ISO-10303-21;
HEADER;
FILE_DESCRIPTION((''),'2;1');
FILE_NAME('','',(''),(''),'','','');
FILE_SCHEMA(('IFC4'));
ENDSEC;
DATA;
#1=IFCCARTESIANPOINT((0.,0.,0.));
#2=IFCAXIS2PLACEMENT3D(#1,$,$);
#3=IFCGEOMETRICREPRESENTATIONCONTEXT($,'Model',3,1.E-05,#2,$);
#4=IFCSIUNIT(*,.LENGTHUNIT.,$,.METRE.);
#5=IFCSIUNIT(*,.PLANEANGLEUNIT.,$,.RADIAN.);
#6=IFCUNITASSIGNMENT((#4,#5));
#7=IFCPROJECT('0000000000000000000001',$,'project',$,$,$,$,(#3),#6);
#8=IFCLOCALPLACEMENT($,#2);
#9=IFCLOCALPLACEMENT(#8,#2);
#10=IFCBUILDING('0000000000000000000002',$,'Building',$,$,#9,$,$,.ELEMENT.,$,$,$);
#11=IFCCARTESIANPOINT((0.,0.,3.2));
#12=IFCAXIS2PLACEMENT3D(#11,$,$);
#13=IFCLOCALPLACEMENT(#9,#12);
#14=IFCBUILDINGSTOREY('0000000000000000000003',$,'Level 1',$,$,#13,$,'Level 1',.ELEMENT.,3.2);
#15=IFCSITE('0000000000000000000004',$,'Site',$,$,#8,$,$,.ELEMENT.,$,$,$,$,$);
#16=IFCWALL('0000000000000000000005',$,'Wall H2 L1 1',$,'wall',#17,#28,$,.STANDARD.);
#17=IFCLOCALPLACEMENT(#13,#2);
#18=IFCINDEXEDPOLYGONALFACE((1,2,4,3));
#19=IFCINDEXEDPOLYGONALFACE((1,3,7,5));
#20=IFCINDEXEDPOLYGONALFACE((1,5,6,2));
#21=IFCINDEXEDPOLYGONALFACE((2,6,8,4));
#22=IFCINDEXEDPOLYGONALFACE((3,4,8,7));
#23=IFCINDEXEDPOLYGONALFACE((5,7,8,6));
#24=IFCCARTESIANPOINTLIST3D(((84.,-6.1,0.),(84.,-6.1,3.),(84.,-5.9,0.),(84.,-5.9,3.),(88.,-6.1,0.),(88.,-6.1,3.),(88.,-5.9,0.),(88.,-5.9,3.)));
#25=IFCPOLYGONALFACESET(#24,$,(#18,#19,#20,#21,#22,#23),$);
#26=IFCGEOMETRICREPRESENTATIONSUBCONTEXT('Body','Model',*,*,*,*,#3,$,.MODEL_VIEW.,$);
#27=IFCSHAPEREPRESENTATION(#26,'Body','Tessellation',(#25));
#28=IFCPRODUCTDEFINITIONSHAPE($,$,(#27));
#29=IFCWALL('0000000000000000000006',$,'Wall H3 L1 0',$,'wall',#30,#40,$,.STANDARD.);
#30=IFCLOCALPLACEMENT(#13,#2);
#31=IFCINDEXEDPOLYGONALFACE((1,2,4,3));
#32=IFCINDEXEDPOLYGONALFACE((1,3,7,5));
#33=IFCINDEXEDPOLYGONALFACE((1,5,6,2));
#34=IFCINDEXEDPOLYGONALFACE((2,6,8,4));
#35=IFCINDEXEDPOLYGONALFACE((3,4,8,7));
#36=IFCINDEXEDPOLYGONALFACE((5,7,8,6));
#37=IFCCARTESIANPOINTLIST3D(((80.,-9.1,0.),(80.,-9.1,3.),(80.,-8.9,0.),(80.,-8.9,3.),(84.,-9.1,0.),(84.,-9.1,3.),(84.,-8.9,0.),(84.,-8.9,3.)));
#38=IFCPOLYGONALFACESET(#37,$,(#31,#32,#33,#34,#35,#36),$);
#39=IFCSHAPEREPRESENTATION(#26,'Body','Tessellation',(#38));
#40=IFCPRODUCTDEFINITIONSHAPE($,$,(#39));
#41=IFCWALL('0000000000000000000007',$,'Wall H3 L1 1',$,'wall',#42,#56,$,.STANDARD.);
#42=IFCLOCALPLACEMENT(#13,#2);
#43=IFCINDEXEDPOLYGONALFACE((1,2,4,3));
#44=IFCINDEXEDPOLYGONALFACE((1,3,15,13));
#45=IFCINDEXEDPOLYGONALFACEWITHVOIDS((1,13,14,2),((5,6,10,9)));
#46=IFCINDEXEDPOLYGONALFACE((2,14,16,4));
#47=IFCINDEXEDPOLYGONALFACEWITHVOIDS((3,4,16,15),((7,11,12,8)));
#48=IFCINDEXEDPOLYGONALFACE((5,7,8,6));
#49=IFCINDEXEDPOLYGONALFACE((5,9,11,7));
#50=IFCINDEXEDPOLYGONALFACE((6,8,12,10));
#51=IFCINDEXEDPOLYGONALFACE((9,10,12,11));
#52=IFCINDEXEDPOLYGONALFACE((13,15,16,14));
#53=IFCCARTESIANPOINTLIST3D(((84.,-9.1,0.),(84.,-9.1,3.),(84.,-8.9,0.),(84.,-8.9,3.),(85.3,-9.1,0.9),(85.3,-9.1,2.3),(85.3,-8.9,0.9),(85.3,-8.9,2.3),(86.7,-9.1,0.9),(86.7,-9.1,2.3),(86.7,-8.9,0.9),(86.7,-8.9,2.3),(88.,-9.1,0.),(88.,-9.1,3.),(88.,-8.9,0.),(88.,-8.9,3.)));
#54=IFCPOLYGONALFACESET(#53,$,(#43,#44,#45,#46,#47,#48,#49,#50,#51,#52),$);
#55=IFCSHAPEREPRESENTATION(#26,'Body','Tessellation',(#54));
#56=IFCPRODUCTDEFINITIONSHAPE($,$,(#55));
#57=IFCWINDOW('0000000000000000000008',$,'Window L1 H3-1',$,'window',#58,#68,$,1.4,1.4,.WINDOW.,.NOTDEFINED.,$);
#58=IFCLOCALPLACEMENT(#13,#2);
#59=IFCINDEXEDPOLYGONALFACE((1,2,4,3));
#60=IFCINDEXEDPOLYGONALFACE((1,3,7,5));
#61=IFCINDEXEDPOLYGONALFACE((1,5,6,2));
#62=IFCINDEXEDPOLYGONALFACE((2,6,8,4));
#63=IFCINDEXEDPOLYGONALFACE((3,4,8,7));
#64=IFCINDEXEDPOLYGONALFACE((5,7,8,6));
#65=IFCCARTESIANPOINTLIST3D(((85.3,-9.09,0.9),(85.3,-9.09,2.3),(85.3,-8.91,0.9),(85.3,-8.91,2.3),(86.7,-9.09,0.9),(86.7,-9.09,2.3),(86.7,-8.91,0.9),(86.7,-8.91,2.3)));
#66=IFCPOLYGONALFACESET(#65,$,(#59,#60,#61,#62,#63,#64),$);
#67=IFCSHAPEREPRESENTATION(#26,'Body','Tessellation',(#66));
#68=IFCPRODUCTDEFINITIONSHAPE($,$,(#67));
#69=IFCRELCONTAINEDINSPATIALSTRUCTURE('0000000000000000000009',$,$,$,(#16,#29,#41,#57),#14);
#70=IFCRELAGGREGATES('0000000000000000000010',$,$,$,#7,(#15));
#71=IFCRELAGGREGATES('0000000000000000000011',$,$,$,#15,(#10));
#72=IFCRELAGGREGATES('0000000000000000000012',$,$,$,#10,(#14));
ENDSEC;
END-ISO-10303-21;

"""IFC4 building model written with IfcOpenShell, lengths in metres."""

from ifc_helpers import new_model, si_unit, frame, frame_2d, origin, origin_2d, place, context, subcontext, project, spatial, rectangle, extrude, element, fill, save


model = new_model("IFC4")

# Units and contexts
model_context = context("Model", 3, precision=1e-05, world=origin())
body_context = subcontext(model_context, "Body", "Model", "MODEL_VIEW")
ifc_project = project(units=[si_unit("LENGTHUNIT", "METRE"), si_unit("PLANEANGLEUNIT", "RADIAN")], contexts=[model_context])

# Site, building, storey
site_placement = place(None, origin())
site = spatial("IfcSite", under=ifc_project, at=site_placement, Name="Site", CompositionType="ELEMENT")
building_placement = place(site_placement, origin())
building = spatial("IfcBuilding", under=site, at=building_placement, Name="Building", CompositionType="ELEMENT")
storey_placement = place(building_placement, frame((0.0, 0.0, 3.2)))
storey = spatial("IfcBuildingStorey", under=building, at=storey_placement, Name="Level 1", LongName="Level 1", CompositionType="ELEMENT", Elevation=3.2)

# Walls
for number, where, z_axis, x_axis, name in (
    (1, (84.0, -6.0, 0.0), (0.0, 0.0, 1.0), (1.0, 0.0, 0.0), "Wall H2 L1 1"),
    (2, (80.0, -9.0, 0.0), (0.0, 0.0, 1.0), (1.0, 0.0, 0.0), "Wall H3 L1 0"),
):
    element("IfcWall", number, at=place(storey_placement, frame(where, z_axis=z_axis, x_axis=x_axis)), inside=storey, Name=name, ObjectType="wall", PredefinedType="STANDARD", context=body_context, shape_type="SweptSolid", body=[
        extrude(rectangle(XDim=4.0, YDim=0.2, at=frame_2d((2.0, 0.0))), origin(), (0.0, 0.0, 1.0), 3.0),
    ])

# Wall, opening, window
wall_1_placement = place(storey_placement, frame((84.0, -9.0, 0.0), z_axis=(0.0, 0.0, 1.0), x_axis=(1.0, 0.0, 0.0)))
wall_1 = element("IfcWall", 3, at=wall_1_placement, inside=storey, Name="Wall H3 L1 1", ObjectType="wall", PredefinedType="STANDARD", context=body_context, shape_type="SweptSolid", body=[
    extrude(rectangle(XDim=4.0, YDim=0.2, at=frame_2d((2.0, 0.0))), origin(), (0.0, 0.0, 1.0), 3.0),
])
opening_1_placement = place(storey_placement, frame((86.0, -9.0, 0.9), z_axis=(0.0, 0.0, 1.0), x_axis=(1.0, 0.0, 0.0)))
opening_1 = element("IfcOpeningElement", 4, at=opening_1_placement, cuts=wall_1, ObjectType="Opening", PredefinedType="OPENING", context=body_context, shape_type="SweptSolid", body=[
    extrude(rectangle(XDim=1.4, YDim=0.22, at=origin_2d()), origin(), (0.0, 0.0, 1.0), 1.4),
])
window_1_placement = place(storey_placement, frame((86.0, -9.0, 0.9), z_axis=(0.0, 0.0, 1.0), x_axis=(1.0, 0.0, 0.0)))
window_1 = element("IfcWindow", 5, at=window_1_placement, inside=storey, Name="Window L1 H3-1", ObjectType="window", OverallHeight=1.4, OverallWidth=1.4, PartitioningType="NOTDEFINED", PredefinedType="WINDOW", context=body_context, shape_type="SweptSolid", body=[
    extrude(rectangle(XDim=1.4, YDim=0.18, at=origin_2d()), origin(), (0.0, 0.0, 1.0), 1.4),
])
fill(opening_1, window_1)

save(model, "model.ifc")
